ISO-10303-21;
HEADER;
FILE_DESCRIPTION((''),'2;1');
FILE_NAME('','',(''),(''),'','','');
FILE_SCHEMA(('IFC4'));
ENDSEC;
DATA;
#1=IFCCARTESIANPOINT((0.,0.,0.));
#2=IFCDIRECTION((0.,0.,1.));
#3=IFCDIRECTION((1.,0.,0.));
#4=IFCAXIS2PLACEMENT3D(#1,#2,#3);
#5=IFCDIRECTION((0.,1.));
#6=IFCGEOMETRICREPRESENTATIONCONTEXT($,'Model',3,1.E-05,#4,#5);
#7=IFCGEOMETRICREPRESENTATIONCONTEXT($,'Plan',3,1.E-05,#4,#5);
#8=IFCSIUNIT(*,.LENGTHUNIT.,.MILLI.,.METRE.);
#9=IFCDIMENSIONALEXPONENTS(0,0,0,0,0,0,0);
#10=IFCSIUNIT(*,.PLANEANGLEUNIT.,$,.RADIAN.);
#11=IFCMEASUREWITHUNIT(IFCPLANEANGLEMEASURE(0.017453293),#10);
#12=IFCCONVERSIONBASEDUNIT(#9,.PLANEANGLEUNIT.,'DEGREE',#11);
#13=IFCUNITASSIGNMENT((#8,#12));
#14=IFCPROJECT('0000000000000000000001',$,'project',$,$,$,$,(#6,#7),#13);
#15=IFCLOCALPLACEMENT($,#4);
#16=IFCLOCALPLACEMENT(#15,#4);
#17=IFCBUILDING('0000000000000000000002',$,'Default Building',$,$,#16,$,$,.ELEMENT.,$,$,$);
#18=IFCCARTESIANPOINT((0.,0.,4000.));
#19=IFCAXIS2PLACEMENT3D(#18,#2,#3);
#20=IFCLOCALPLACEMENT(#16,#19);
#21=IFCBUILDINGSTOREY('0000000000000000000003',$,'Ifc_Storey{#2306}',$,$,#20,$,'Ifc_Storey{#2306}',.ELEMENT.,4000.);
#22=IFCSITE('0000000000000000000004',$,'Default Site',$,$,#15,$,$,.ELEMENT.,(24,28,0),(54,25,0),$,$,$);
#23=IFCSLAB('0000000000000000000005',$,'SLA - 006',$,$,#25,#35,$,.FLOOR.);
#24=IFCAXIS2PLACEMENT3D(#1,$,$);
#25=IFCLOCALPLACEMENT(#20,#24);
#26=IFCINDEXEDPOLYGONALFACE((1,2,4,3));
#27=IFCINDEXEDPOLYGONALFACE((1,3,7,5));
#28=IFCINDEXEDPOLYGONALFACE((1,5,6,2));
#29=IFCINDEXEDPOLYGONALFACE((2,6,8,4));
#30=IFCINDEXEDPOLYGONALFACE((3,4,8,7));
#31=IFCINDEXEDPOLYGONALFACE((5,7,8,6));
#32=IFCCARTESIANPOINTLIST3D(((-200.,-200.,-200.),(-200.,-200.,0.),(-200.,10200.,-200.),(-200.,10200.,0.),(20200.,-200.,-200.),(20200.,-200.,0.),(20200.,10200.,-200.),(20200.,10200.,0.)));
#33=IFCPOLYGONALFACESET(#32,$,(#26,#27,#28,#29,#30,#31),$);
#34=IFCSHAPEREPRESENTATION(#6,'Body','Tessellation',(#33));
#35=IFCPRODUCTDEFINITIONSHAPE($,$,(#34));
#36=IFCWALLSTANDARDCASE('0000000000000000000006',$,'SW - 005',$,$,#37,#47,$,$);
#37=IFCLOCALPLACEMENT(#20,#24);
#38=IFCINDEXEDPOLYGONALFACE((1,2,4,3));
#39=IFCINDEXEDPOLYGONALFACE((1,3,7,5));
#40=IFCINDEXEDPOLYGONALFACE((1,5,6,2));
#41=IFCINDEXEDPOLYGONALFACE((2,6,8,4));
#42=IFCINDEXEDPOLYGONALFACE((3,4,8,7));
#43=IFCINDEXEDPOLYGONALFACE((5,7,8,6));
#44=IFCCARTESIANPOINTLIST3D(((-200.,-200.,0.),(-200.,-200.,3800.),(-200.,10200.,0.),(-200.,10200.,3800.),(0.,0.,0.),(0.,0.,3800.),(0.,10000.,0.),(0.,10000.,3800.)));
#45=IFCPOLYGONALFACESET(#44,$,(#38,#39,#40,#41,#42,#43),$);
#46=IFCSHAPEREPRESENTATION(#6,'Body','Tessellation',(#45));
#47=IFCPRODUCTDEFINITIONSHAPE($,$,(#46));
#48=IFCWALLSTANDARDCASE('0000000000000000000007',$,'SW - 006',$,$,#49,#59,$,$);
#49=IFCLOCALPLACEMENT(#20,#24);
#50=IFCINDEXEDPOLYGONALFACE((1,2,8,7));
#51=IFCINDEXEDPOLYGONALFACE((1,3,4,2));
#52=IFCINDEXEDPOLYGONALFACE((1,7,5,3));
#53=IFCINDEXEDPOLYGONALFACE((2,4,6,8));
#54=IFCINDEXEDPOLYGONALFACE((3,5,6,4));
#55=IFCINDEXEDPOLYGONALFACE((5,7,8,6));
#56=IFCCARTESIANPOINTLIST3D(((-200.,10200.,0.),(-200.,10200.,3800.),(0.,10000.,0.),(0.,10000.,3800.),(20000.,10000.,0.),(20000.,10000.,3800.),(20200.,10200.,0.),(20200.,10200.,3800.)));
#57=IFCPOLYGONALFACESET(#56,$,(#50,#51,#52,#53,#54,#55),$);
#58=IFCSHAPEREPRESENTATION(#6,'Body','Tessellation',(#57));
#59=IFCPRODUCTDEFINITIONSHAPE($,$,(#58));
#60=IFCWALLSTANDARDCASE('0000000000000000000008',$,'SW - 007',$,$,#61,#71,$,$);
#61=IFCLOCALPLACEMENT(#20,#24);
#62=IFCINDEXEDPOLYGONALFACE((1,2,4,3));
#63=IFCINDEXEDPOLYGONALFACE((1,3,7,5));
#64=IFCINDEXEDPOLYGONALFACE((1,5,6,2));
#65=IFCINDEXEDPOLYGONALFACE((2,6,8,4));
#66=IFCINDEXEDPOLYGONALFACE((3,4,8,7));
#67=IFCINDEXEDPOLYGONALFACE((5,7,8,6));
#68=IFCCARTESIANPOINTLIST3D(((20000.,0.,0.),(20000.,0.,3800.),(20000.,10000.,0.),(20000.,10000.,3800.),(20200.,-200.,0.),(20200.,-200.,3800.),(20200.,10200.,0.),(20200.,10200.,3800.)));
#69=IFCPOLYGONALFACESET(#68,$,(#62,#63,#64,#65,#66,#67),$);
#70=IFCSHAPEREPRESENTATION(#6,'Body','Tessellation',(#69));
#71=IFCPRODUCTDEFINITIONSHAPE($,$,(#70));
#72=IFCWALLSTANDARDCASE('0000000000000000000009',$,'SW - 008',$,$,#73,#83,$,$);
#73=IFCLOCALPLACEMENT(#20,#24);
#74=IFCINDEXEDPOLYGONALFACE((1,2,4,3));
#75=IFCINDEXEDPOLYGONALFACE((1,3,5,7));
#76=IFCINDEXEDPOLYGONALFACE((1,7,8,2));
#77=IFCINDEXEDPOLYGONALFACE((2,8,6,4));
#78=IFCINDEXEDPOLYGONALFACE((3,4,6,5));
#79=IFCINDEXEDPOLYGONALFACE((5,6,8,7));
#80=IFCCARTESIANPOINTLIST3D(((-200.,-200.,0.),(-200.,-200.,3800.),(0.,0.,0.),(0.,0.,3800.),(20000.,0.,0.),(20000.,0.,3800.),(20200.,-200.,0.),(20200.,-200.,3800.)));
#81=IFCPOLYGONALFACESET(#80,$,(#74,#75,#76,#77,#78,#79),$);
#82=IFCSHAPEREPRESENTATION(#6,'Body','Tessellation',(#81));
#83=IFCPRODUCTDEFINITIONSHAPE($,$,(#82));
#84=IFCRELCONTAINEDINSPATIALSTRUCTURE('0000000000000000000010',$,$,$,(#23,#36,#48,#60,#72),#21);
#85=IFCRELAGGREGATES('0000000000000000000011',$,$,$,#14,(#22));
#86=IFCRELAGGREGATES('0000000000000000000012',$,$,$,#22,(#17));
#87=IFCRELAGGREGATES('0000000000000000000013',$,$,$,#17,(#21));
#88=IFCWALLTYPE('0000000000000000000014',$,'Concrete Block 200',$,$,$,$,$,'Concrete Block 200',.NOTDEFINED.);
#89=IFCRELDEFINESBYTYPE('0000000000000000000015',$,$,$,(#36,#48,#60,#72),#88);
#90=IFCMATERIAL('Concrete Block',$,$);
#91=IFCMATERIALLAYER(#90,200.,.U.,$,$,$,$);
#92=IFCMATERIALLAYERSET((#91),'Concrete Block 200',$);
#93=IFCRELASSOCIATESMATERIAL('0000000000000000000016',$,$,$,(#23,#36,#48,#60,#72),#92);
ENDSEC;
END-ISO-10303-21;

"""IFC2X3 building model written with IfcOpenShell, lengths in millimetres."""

from ifc_helpers import new_model, entity, si_unit, converted_unit, direction, frame, origin_with_axes, place, context, project, spatial, polyline, outline, extrude, material, layer, layer_set, layer_usage, type_object, element, save


model = new_model("IFC2X3")

# Units and contexts
model_context = context("Model", 3, precision=1e-05, world=origin_with_axes(), true_north=direction((0.0, 1.0)))
plan_context = context("Plan", 3, precision=1e-05, world=origin_with_axes(), true_north=direction((0.0, 1.0)))
ifc_project = project(units=[si_unit("LENGTHUNIT", "METRE", prefix="MILLI"), converted_unit("PLANEANGLEUNIT", "DEGREE", entity("IfcPlaneAngleMeasure", 0.017453293), si_unit("PLANEANGLEUNIT", "RADIAN"), dimensions=[0, 0, 0, 0, 0, 0, 0])], contexts=[model_context, plan_context])

# Site, building, storey
site_placement = place(None, origin_with_axes())
site = spatial("IfcSite", under=ifc_project, at=site_placement, Name="Default Site", CompositionType="ELEMENT", RefLatitude=(24, 28, 0), RefLongitude=(54, 25, 0))
building_placement = place(site_placement, origin_with_axes())
building = spatial("IfcBuilding", under=site, at=building_placement, Name="Default Building", CompositionType="ELEMENT")
storey_placement = place(building_placement, frame((0.0, 0.0, 4000.0), z_axis=(0.0, 0.0, 1.0), x_axis=(1.0, 0.0, 0.0)))
storey = spatial("IfcBuildingStorey", under=building, at=storey_placement, Name="Ifc_Storey{#2306}", LongName="Ifc_Storey{#2306}", CompositionType="ELEMENT", Elevation=4000.0)

# Slab
ifc_material = material(Name="Concrete Block")
ifc_layer = layer(ifc_material, 200.0, ventilated="UNKNOWN")
ifc_layer_set = layer_set([ifc_layer], Name="Concrete Block 200")
ifc_layer_usage_1 = layer_usage(ifc_layer_set, "AXIS3", "NEGATIVE", 200.0)
slab_placement = place(storey_placement, frame((-200.0, 10200.0, -200.0), z_axis=(0.0, 0.0, 1.0), x_axis=(1.0, 0.0, 0.0)))
element("IfcSlab", 1, at=slab_placement, inside=storey, material=ifc_layer_usage_1, Name="SLA - 006", PredefinedType="FLOOR", context=model_context, shape_type="SweptSolid", body=[
    extrude(outline(polyline([(0.0, 0.0), (20400.0, 0.0), (20400.0, -10400.0), (0.0, -10400.0), (0.0, 0.0)])), origin_with_axes(), (0.0, 0.0, 1.0), 200.0),
])

# Walls
ifc_layer_usage_2 = layer_usage(ifc_layer_set, "AXIS2", "POSITIVE", 0.0)
wall_type = type_object("IfcWallType", Name="Concrete Block 200", ElementType="Concrete Block 200", PredefinedType="NOTDEFINED")
wall_1_placement = place(storey_placement, frame((0.0, 0.0, 0.0), z_axis=(0.0, 0.0, 1.0), x_axis=(0.0, 1.0, 0.0)))
element("IfcWallStandardCase", 2, at=wall_1_placement, inside=storey, type_object=wall_type, material=ifc_layer_usage_2, Name="SW - 005", context=model_context, shape_type="SweptSolid", body=[
    extrude(outline(polyline([(0.0, 0.0), (10000.0, 0.0), (10200.0, 200.0), (-200.0, 200.0), (0.0, 0.0)])), origin_with_axes(), (0.0, 0.0, 1.0), 3800.0),
])
ifc_layer_usage_3 = layer_usage(ifc_layer_set, "AXIS2", "POSITIVE", 0.0)
wall_2_placement = place(storey_placement, frame((0.0, 10000.0, 0.0), z_axis=(0.0, 0.0, 1.0), x_axis=(1.0, 0.0, 0.0)))
element("IfcWallStandardCase", 3, at=wall_2_placement, inside=storey, type_object=wall_type, material=ifc_layer_usage_3, Name="SW - 006", context=model_context, shape_type="SweptSolid", body=[
    extrude(outline(polyline([(0.0, 0.0), (20000.0, 0.0), (20200.0, 200.0), (-200.0, 200.0), (0.0, 0.0)])), origin_with_axes(), (0.0, 0.0, 1.0), 3800.0),
])
ifc_layer_usage_4 = layer_usage(ifc_layer_set, "AXIS2", "POSITIVE", 0.0)
wall_3_placement = place(storey_placement, frame((20000.0, 10000.0, 0.0), z_axis=(0.0, 0.0, 1.0), x_axis=(0.0, -1.0, 0.0)))
element("IfcWallStandardCase", 4, at=wall_3_placement, inside=storey, type_object=wall_type, material=ifc_layer_usage_4, Name="SW - 007", context=model_context, shape_type="SweptSolid", body=[
    extrude(outline(polyline([(0.0, 0.0), (10000.0, 0.0), (10200.0, 200.0), (-200.0, 200.0), (0.0, 0.0)])), origin_with_axes(), (0.0, 0.0, 1.0), 3800.0),
])
ifc_layer_usage_5 = layer_usage(ifc_layer_set, "AXIS2", "POSITIVE", 0.0)
wall_4_placement = place(storey_placement, frame((20000.0, 0.0, 0.0), z_axis=(0.0, 0.0, 1.0), x_axis=(-1.0, 0.0, 0.0)))
element("IfcWallStandardCase", 5, at=wall_4_placement, inside=storey, type_object=wall_type, material=ifc_layer_usage_5, Name="SW - 008", context=model_context, shape_type="SweptSolid", body=[
    extrude(outline(polyline([(0.0, 0.0), (20000.0, 0.0), (20200.0, 200.0), (-200.0, 200.0), (0.0, 0.0)])), origin_with_axes(), (0.0, 0.0, 1.0), 3800.0),
])

save(model, "model.ifc")
